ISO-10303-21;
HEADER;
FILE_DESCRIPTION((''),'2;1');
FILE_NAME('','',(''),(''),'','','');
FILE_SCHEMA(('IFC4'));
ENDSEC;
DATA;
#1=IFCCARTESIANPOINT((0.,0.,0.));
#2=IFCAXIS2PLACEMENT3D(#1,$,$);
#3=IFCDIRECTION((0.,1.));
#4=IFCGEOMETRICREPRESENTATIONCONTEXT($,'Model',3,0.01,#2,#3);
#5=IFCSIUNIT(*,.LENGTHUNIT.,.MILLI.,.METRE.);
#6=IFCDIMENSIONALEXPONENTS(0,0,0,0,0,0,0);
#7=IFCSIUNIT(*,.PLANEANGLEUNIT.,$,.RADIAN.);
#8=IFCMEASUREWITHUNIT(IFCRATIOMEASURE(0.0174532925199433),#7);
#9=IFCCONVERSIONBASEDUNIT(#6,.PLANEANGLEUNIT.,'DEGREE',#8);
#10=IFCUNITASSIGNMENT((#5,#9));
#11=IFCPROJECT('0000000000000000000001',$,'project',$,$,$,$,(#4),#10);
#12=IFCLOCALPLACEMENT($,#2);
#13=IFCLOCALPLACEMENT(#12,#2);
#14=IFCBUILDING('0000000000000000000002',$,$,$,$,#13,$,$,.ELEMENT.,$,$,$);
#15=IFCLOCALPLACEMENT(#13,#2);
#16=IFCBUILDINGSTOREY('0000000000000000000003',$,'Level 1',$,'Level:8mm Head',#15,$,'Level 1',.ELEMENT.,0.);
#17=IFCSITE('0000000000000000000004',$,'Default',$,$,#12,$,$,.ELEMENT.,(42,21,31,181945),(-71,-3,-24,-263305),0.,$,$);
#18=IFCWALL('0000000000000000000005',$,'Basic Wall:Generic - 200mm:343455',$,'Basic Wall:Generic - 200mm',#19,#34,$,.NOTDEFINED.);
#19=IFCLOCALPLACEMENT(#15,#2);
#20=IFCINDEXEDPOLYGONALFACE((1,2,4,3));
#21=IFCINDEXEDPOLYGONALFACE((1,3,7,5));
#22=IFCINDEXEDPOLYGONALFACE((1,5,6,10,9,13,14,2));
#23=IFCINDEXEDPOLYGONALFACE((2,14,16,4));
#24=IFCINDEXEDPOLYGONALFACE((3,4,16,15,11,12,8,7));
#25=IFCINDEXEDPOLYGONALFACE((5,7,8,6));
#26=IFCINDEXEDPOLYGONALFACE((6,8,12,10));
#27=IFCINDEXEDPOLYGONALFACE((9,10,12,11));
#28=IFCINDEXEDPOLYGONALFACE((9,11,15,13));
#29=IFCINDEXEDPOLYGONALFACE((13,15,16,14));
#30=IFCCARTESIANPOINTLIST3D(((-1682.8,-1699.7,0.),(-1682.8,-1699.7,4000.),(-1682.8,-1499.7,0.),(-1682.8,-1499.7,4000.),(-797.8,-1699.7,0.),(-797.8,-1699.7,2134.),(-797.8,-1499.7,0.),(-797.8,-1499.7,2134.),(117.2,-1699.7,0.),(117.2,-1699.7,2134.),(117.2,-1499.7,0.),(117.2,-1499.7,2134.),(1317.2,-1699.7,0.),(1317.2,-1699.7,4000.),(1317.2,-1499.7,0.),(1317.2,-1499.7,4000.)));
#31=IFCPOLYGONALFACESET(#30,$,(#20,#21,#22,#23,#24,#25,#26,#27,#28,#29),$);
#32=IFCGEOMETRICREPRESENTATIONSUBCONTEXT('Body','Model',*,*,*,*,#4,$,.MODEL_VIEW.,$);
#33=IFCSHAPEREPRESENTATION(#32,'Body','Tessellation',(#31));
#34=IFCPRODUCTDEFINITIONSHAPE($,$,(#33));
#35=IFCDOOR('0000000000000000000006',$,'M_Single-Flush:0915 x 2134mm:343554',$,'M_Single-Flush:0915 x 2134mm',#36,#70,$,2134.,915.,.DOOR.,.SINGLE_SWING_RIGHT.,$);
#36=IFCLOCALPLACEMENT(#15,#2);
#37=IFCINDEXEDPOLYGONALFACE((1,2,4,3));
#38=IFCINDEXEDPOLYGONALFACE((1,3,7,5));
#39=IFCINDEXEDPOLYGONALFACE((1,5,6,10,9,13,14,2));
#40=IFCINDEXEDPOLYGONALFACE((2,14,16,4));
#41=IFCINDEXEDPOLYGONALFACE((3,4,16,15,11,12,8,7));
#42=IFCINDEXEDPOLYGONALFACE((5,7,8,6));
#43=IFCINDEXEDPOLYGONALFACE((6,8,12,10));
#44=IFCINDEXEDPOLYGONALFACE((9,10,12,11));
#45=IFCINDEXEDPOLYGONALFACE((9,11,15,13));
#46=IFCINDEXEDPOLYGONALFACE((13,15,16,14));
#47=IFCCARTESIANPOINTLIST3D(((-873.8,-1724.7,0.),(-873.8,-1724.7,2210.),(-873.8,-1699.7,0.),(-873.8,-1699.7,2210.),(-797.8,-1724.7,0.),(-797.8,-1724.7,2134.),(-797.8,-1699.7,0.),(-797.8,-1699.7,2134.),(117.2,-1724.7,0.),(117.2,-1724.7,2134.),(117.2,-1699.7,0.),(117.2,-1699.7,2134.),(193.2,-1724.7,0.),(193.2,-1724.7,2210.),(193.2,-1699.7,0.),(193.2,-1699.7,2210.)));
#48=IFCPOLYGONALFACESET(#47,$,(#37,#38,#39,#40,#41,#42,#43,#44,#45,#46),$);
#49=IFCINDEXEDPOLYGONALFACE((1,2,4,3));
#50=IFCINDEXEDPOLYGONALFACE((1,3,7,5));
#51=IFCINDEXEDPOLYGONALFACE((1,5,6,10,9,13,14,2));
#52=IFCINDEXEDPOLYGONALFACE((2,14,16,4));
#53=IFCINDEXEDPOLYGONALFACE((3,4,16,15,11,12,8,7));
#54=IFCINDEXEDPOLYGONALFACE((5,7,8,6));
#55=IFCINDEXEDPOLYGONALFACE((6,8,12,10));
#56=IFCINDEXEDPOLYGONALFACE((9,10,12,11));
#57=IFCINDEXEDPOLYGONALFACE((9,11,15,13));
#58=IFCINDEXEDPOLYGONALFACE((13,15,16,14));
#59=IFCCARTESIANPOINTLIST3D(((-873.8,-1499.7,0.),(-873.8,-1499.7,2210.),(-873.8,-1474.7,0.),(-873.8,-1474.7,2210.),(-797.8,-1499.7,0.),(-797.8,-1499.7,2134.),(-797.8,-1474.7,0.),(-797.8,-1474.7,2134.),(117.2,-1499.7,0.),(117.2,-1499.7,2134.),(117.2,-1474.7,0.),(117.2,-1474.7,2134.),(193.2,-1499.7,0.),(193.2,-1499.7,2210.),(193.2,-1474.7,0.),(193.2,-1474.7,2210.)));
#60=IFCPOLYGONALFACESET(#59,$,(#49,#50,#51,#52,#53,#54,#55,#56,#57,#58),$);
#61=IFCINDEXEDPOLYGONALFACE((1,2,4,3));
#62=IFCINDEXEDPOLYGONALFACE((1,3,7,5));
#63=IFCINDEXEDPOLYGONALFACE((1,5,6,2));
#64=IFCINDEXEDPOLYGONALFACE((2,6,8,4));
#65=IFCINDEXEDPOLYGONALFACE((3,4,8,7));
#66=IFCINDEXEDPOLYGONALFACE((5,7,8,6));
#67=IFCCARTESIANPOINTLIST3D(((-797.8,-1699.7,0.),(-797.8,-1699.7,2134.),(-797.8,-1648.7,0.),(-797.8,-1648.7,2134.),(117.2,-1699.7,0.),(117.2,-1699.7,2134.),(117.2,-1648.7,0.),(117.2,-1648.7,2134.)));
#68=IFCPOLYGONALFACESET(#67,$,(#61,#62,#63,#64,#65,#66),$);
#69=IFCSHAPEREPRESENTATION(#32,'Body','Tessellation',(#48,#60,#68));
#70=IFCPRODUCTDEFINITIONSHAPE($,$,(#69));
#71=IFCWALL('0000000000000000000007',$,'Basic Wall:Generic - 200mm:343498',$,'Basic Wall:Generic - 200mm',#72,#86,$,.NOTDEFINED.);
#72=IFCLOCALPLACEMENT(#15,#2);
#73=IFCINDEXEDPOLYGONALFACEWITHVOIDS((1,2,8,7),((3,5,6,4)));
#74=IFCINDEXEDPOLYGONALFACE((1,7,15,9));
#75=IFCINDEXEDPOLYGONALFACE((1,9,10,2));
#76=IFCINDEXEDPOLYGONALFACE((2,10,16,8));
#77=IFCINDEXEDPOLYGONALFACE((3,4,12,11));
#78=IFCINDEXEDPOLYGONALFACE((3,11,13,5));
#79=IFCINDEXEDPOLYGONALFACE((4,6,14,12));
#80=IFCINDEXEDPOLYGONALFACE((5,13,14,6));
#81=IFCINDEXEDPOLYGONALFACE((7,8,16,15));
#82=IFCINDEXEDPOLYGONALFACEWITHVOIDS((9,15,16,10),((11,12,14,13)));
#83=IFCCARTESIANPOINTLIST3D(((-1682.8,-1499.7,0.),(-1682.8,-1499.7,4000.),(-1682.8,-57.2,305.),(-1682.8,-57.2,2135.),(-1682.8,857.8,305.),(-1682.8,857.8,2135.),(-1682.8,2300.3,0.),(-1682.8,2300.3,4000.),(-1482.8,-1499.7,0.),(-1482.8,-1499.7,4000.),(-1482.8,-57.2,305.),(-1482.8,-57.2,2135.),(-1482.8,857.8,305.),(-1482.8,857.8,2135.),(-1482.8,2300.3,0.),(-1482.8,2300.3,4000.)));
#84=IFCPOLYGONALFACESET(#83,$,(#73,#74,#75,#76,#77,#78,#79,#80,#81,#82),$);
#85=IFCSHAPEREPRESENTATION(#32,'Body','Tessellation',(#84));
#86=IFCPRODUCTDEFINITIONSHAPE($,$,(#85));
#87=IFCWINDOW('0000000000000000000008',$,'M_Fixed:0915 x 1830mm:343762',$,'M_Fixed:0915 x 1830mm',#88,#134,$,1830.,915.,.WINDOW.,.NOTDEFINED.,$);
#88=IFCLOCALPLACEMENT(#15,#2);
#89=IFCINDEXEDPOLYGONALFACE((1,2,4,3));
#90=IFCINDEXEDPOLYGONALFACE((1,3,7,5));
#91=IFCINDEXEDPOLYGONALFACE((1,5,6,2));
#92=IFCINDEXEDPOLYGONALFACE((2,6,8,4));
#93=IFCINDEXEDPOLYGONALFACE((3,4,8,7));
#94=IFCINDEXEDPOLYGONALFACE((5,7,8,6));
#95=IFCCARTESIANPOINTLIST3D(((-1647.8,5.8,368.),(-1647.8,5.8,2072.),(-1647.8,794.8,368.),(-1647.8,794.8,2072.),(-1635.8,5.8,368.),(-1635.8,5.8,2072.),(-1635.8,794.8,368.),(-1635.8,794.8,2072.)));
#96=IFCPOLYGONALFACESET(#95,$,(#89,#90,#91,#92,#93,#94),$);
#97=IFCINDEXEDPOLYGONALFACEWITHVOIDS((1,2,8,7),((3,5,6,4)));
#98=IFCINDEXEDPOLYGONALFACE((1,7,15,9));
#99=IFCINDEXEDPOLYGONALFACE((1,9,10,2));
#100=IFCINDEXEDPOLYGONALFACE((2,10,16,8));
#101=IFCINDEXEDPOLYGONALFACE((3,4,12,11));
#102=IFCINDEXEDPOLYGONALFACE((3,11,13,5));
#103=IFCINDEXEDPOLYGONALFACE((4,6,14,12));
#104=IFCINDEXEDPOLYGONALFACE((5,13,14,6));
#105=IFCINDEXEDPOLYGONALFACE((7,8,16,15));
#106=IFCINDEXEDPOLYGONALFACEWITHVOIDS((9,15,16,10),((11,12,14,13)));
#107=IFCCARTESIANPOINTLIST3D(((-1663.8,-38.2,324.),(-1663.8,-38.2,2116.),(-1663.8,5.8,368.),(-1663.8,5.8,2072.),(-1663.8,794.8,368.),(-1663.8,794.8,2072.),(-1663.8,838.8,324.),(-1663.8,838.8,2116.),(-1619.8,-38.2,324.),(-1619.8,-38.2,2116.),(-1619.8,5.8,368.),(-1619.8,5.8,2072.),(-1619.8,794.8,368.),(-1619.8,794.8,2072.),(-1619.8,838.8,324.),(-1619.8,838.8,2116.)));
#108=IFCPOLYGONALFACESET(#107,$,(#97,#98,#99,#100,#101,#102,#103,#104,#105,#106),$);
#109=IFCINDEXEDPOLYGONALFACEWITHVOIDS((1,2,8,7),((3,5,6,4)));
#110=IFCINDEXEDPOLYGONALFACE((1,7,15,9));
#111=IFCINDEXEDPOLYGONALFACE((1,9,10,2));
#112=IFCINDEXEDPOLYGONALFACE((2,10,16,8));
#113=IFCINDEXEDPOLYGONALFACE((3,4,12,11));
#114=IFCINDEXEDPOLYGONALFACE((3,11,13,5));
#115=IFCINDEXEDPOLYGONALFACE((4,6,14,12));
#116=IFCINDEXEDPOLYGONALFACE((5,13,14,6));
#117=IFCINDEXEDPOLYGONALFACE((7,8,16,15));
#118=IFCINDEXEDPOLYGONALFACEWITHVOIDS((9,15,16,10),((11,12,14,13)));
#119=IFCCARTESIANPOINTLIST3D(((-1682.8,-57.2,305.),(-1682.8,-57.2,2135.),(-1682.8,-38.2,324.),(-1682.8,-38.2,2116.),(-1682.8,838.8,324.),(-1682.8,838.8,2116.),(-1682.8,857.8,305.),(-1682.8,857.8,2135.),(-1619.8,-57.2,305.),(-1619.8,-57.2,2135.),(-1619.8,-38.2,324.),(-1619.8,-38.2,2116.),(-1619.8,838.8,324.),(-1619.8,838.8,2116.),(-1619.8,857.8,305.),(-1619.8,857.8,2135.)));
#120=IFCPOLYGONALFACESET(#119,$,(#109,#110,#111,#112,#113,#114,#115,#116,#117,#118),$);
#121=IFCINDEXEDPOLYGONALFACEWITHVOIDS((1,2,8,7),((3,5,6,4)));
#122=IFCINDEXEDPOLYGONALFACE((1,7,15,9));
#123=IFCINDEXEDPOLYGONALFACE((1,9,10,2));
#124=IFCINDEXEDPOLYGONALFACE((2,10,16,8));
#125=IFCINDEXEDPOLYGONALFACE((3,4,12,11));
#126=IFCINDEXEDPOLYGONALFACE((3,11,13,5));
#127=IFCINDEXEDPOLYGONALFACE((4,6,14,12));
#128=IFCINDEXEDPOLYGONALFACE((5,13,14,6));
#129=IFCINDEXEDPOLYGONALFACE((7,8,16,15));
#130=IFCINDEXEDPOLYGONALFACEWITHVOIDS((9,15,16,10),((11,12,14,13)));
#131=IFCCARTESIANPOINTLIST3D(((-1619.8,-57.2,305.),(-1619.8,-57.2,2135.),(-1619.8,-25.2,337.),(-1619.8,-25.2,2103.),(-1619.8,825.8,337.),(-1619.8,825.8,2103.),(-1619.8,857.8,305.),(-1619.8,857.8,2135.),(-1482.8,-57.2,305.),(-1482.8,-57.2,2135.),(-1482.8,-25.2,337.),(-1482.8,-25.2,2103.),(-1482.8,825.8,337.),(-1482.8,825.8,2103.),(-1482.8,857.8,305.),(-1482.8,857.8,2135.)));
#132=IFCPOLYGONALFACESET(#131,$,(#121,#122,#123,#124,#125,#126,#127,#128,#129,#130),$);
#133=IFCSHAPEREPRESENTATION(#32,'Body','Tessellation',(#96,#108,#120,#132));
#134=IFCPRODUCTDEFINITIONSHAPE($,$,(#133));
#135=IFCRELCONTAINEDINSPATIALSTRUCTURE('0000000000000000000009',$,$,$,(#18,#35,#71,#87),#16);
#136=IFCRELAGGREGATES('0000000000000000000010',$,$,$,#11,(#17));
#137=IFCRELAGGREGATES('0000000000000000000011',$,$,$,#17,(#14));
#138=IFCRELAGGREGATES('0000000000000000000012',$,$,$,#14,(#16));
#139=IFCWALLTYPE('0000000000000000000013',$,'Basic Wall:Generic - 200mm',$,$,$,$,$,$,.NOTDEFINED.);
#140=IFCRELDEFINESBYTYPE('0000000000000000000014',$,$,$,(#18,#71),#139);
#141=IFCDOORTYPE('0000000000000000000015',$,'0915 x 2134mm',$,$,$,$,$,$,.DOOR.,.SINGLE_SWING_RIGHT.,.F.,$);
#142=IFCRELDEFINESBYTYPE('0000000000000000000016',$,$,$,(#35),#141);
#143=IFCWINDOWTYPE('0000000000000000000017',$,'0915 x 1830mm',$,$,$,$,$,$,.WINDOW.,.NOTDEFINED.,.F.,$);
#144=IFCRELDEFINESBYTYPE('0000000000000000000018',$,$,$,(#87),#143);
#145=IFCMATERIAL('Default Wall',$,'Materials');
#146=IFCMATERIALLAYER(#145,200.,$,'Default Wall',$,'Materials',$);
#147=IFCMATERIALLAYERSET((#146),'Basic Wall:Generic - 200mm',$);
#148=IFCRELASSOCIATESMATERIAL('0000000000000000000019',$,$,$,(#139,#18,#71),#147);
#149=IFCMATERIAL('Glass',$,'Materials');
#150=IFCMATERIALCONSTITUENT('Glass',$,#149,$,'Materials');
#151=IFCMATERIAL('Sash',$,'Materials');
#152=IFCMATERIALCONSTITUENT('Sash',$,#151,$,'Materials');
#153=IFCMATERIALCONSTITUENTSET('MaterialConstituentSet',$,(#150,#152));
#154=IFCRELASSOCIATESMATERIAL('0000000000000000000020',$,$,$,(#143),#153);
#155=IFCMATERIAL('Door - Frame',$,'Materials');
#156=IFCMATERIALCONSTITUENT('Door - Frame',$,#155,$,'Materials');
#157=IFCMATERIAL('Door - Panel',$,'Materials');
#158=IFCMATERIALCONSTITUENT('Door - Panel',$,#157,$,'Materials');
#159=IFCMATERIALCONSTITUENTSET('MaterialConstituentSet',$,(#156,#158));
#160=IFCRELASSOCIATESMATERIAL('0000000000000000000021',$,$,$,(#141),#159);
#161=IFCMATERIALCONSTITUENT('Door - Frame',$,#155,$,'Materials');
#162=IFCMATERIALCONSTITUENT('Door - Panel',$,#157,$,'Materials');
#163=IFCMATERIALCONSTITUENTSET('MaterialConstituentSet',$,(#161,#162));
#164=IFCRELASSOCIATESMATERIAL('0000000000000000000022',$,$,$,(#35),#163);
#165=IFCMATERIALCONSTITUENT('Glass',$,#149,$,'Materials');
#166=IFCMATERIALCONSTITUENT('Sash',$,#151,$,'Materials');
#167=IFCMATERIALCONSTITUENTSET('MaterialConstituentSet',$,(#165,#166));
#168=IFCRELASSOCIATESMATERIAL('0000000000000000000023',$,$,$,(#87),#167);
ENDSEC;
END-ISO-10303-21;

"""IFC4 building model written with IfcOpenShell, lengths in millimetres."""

from ifc_helpers import new_model, entity, si_unit, converted_unit, direction, frame, frame_2d, origin, place, context, subcontext, project, spatial, polyline, rectangle, outline, extrude, source, transform, mapped, material, layer, layer_set, layer_usage, constituent, constituent_set, type_object, type_shapes, element, fill, save


model = new_model("IFC4")

# Units and contexts
model_context = context("Model", 3, precision=0.01, world=origin(), true_north=direction((0.0, 1.0)))
body_context = subcontext(model_context, "Body", "Model", "MODEL_VIEW")
ifc_project = project(units=[si_unit("LENGTHUNIT", "METRE", prefix="MILLI"), converted_unit("PLANEANGLEUNIT", "DEGREE", entity("IfcRatioMeasure", 0.0174532925199433), si_unit("PLANEANGLEUNIT", "RADIAN"), dimensions=[0, 0, 0, 0, 0, 0, 0])], contexts=[model_context])

# Site, building, storey
site_placement = place(None, origin())
site = spatial("IfcSite", under=ifc_project, at=site_placement, Name="Default", CompositionType="ELEMENT", RefLatitude=(42, 21, 31, 181945), RefLongitude=(-71, -3, -24, -263305), RefElevation=0.0)
building_placement = place(site_placement, origin())
building = spatial("IfcBuilding", under=site, at=building_placement, CompositionType="ELEMENT")
storey_placement = place(building_placement, origin())
storey = spatial("IfcBuildingStorey", under=building, at=storey_placement, Name="Level 1", ObjectType="Level:8mm Head", LongName="Level 1", CompositionType="ELEMENT", Elevation=0.0)

# Shared definitions
ifc_material_1 = material(Name="Default Wall", Category="Materials")
ifc_layer_1 = layer(ifc_material_1, 200.0, Name="Default Wall", Category="Materials")
ifc_layer_set_1 = layer_set([ifc_layer_1], Name="Basic Wall:Generic - 200mm")
wall_type = type_object("IfcWallType", Name="Basic Wall:Generic - 200mm", PredefinedType="NOTDEFINED", material=ifc_layer_set_1)
ifc_material_2 = material(Name="Glass", Category="Materials")
ifc_material_3 = material(Name="Sash", Category="Materials")
ifc_constituent_1 = constituent(ifc_material_2, Name="Glass", Category="Materials")
ifc_constituent_2 = constituent(ifc_material_3, Name="Sash", Category="Materials")
ifc_constituent_set_1 = constituent_set(constituents=[ifc_constituent_1, ifc_constituent_2], Name="MaterialConstituentSet")
window_type = type_object("IfcWindowType", Name="0915 x 1830mm", ParameterTakesPrecedence=False, PartitioningType="NOTDEFINED", PredefinedType="WINDOW", material=ifc_constituent_set_1)
shared_shape_1 = source(origin(), body_context, "Body", "SweptSolid", [
    extrude(rectangle(XDim=12.0, YDim=789.0, at=frame_2d((0.0, 0.0), x_axis=(1.0, 0.0))), frame((457.5, 159.0, 63.0), z_axis=(0.0, 0.0, 1.0), x_axis=(0.0, -1.0, 0.0)), (0.0, 0.0, 1.0), 1704.0),
    extrude(outline(polyline([(-438.5, -896.0), (438.5, -896.0), (438.5, 896.0), (-438.5, 896.0), (-438.5, -896.0)]), holes=[polyline([(-394.5, -852.0), (-394.5, 852.0), (394.5, 852.0), (394.5, -852.0), (-394.5, -852.0)])]), frame((457.5, 137.0, 915.0), z_axis=(0.0, 1.0, 0.0), x_axis=(1.0, 0.0, 0.0)), (0.0, 0.0, 1.0), 44.0),
    extrude(outline(polyline([(-457.5, -915.0), (457.5, -915.0), (457.5, 915.0), (-457.5, 915.0), (-457.5, -915.0)]), holes=[polyline([(-438.5, -896.0), (-438.5, 896.0), (438.5, 896.0), (438.5, -896.0), (-438.5, -896.0)])]), frame((457.5, 137.0, 915.0), z_axis=(0.0, 1.0, 0.0), x_axis=(1.0, 0.0, 0.0)), (0.0, 0.0, 1.0), 63.0),
    extrude(outline(polyline([(-457.5, -915.0), (457.5, -915.0), (457.5, 915.0), (-457.5, 915.0), (-457.5, -915.0)]), holes=[polyline([(-425.5, -883.0), (-425.5, 883.0), (425.5, 883.0), (425.5, -883.0), (-425.5, -883.0)])]), frame((457.5, 0.0, 915.0), z_axis=(0.0, 1.0, 0.0), x_axis=(1.0, 0.0, 0.0)), (0.0, 0.0, 1.0), 137.0),
])
type_shapes(window_type, [shared_shape_1])

# Wall, opening, door
ifc_layer_usage_1 = layer_usage(ifc_layer_set_1, "AXIS2", "NEGATIVE", 100.0)
wall_1_placement = place(storey_placement, frame((1317.2, -1599.7, 0.0), z_axis=(0.0, 0.0, 1.0), x_axis=(-1.0, 0.0, 0.0)))
wall_1 = element("IfcWall", 1, at=wall_1_placement, inside=storey, type_object=wall_type, material=ifc_layer_usage_1, Name="Basic Wall:Generic - 200mm:343455", ObjectType="Basic Wall:Generic - 200mm", PredefinedType="NOTDEFINED", context=body_context, shape_type="SweptSolid", body=[
    extrude(rectangle(XDim=3000.0, YDim=200.0, at=frame_2d((1500.0, 0.0), x_axis=(-1.0, 0.0))), origin(), (0.0, 0.0, 1.0), 4000.0),
])
opening_1_placement = place(wall_1_placement, frame((1200.0, -100.0, 0.0)))
opening_1 = element("IfcOpeningElement", 2, at=opening_1_placement, cuts=wall_1, ObjectType="Opening", PredefinedType="OPENING", context=body_context, shape_type="SweptSolid", body=[
    extrude(rectangle(XDim=915.0, YDim=2134.0, at=frame_2d((1067.0, 457.5), x_axis=(0.0, 1.0))), frame((0.0, 0.0, 0.0), z_axis=(0.0, 1.0, 0.0), x_axis=(0.0, 0.0, 1.0)), (0.0, 0.0, 1.0), 200.0),
])
ifc_material_4 = material(Name="Door - Frame", Category="Materials")
ifc_constituent_3 = constituent(ifc_material_4, Name="Door - Frame", Category="Materials")
ifc_material_5 = material(Name="Door - Panel", Category="Materials")
ifc_constituent_4 = constituent(ifc_material_5, Name="Door - Panel", Category="Materials")
ifc_constituent_set_2 = constituent_set(constituents=[ifc_constituent_3, ifc_constituent_4], Name="MaterialConstituentSet")
ifc_constituent_5 = constituent(ifc_material_4, Name="Door - Frame", Category="Materials")
ifc_constituent_6 = constituent(ifc_material_5, Name="Door - Panel", Category="Materials")
ifc_constituent_set_3 = constituent_set(constituents=[ifc_constituent_5, ifc_constituent_6], Name="MaterialConstituentSet")
door_type = type_object("IfcDoorType", Name="0915 x 2134mm", OperationType="SINGLE_SWING_RIGHT", ParameterTakesPrecedence=False, PredefinedType="DOOR", material=ifc_constituent_set_3)
shared_shape_2 = source(origin(), body_context, "Body", "SweptSolid", [
    extrude(outline(polyline([(-533.5, -1124.0), (533.5, -1124.0), (533.5, 1086.0), (457.5, 1086.0), (457.5, -1048.0), (-457.5, -1048.0), (-457.5, 1086.0), (-533.5, 1086.0), (-533.5, -1124.0)])), frame((457.5, 200.0, 1086.0), z_axis=(0.0, 1.0, 0.0), x_axis=(1.0, 0.0, 0.0)), (0.0, 0.0, 1.0), 25.0),
    extrude(outline(polyline([(-1124.0, -533.5), (1086.0, -533.5), (1086.0, -457.5), (-1048.0, -457.5), (-1048.0, 457.5), (1086.0, 457.5), (1086.0, 533.5), (-1124.0, 533.5), (-1124.0, -533.5)])), frame((457.5, -25.0, 1086.0), z_axis=(0.0, 1.0, 0.0), x_axis=(0.0, 0.0, -1.0)), (0.0, 0.0, 1.0), 25.0),
    extrude(rectangle(XDim=51.0, YDim=915.0, at=frame_2d((0.0, 0.0), x_axis=(1.0, 0.0))), frame((457.5, 174.5, 0.0), z_axis=(0.0, 0.0, 1.0), x_axis=(0.0, 1.0, 0.0)), (0.0, 0.0, 1.0), 2134.0),
])
type_shapes(door_type, [shared_shape_2])
door_placement = place(opening_1_placement, origin())
door = element("IfcDoor", 3, at=door_placement, inside=storey, type_object=door_type, material=ifc_constituent_set_2, Name="M_Single-Flush:0915 x 2134mm:343554", ObjectType="M_Single-Flush:0915 x 2134mm", OperationType="SINGLE_SWING_RIGHT", OverallHeight=2134.0, OverallWidth=915.0, PredefinedType="DOOR", context=body_context, shape_type="MappedRepresentation", body=[
    mapped(shared_shape_2, transform((0.0, 0.0, 0.0), scale=1.0)),
])
fill(opening_1, door)

# Wall, opening, window
ifc_layer_usage_2 = layer_usage(ifc_layer_set_1, "AXIS2", "NEGATIVE", 100.0)
wall_2_placement = place(storey_placement, frame((-1582.8, -1499.7, 0.0), z_axis=(0.0, 0.0, 1.0), x_axis=(0.0, 1.0, 0.0)))
wall_2 = element("IfcWall", 4, at=wall_2_placement, inside=storey, type_object=wall_type, material=ifc_layer_usage_2, Name="Basic Wall:Generic - 200mm:343498", ObjectType="Basic Wall:Generic - 200mm", PredefinedType="NOTDEFINED", context=body_context, shape_type="SweptSolid", body=[
    extrude(rectangle(XDim=3800.0, YDim=200.0, at=frame_2d((1900.0, 0.0), x_axis=(-1.0, 0.0))), origin(), (0.0, 0.0, 1.0), 4000.0),
])
opening_2_placement = place(wall_2_placement, frame((1442.5, -100.0, 305.0)))
opening_2 = element("IfcOpeningElement", 5, at=opening_2_placement, cuts=wall_2, ObjectType="Opening", PredefinedType="OPENING", context=body_context, shape_type="SweptSolid", body=[
    extrude(rectangle(XDim=1830.0, YDim=915.0, at=frame_2d((915.0, 457.5), x_axis=(1.0, 0.0))), frame((0.0, 0.0, 0.0), z_axis=(0.0, 1.0, 0.0), x_axis=(0.0, 0.0, 1.0)), (0.0, 0.0, 1.0), 200.0),
])
ifc_constituent_7 = constituent(ifc_material_2, Name="Glass", Category="Materials")
ifc_constituent_8 = constituent(ifc_material_3, Name="Sash", Category="Materials")
ifc_constituent_set_4 = constituent_set(constituents=[ifc_constituent_7, ifc_constituent_8], Name="MaterialConstituentSet")
window_1_placement = place(opening_2_placement, origin())
window_1 = element("IfcWindow", 6, at=window_1_placement, inside=storey, type_object=window_type, material=ifc_constituent_set_4, Name="M_Fixed:0915 x 1830mm:343762", ObjectType="M_Fixed:0915 x 1830mm", OverallHeight=1830.0, OverallWidth=915.0, PartitioningType="NOTDEFINED", PredefinedType="WINDOW", context=body_context, shape_type="MappedRepresentation", body=[
    mapped(shared_shape_1, transform((0.0, 0.0, 0.0), scale=1.0)),
])
fill(opening_2, window_1)

save(model, "model.ifc")
